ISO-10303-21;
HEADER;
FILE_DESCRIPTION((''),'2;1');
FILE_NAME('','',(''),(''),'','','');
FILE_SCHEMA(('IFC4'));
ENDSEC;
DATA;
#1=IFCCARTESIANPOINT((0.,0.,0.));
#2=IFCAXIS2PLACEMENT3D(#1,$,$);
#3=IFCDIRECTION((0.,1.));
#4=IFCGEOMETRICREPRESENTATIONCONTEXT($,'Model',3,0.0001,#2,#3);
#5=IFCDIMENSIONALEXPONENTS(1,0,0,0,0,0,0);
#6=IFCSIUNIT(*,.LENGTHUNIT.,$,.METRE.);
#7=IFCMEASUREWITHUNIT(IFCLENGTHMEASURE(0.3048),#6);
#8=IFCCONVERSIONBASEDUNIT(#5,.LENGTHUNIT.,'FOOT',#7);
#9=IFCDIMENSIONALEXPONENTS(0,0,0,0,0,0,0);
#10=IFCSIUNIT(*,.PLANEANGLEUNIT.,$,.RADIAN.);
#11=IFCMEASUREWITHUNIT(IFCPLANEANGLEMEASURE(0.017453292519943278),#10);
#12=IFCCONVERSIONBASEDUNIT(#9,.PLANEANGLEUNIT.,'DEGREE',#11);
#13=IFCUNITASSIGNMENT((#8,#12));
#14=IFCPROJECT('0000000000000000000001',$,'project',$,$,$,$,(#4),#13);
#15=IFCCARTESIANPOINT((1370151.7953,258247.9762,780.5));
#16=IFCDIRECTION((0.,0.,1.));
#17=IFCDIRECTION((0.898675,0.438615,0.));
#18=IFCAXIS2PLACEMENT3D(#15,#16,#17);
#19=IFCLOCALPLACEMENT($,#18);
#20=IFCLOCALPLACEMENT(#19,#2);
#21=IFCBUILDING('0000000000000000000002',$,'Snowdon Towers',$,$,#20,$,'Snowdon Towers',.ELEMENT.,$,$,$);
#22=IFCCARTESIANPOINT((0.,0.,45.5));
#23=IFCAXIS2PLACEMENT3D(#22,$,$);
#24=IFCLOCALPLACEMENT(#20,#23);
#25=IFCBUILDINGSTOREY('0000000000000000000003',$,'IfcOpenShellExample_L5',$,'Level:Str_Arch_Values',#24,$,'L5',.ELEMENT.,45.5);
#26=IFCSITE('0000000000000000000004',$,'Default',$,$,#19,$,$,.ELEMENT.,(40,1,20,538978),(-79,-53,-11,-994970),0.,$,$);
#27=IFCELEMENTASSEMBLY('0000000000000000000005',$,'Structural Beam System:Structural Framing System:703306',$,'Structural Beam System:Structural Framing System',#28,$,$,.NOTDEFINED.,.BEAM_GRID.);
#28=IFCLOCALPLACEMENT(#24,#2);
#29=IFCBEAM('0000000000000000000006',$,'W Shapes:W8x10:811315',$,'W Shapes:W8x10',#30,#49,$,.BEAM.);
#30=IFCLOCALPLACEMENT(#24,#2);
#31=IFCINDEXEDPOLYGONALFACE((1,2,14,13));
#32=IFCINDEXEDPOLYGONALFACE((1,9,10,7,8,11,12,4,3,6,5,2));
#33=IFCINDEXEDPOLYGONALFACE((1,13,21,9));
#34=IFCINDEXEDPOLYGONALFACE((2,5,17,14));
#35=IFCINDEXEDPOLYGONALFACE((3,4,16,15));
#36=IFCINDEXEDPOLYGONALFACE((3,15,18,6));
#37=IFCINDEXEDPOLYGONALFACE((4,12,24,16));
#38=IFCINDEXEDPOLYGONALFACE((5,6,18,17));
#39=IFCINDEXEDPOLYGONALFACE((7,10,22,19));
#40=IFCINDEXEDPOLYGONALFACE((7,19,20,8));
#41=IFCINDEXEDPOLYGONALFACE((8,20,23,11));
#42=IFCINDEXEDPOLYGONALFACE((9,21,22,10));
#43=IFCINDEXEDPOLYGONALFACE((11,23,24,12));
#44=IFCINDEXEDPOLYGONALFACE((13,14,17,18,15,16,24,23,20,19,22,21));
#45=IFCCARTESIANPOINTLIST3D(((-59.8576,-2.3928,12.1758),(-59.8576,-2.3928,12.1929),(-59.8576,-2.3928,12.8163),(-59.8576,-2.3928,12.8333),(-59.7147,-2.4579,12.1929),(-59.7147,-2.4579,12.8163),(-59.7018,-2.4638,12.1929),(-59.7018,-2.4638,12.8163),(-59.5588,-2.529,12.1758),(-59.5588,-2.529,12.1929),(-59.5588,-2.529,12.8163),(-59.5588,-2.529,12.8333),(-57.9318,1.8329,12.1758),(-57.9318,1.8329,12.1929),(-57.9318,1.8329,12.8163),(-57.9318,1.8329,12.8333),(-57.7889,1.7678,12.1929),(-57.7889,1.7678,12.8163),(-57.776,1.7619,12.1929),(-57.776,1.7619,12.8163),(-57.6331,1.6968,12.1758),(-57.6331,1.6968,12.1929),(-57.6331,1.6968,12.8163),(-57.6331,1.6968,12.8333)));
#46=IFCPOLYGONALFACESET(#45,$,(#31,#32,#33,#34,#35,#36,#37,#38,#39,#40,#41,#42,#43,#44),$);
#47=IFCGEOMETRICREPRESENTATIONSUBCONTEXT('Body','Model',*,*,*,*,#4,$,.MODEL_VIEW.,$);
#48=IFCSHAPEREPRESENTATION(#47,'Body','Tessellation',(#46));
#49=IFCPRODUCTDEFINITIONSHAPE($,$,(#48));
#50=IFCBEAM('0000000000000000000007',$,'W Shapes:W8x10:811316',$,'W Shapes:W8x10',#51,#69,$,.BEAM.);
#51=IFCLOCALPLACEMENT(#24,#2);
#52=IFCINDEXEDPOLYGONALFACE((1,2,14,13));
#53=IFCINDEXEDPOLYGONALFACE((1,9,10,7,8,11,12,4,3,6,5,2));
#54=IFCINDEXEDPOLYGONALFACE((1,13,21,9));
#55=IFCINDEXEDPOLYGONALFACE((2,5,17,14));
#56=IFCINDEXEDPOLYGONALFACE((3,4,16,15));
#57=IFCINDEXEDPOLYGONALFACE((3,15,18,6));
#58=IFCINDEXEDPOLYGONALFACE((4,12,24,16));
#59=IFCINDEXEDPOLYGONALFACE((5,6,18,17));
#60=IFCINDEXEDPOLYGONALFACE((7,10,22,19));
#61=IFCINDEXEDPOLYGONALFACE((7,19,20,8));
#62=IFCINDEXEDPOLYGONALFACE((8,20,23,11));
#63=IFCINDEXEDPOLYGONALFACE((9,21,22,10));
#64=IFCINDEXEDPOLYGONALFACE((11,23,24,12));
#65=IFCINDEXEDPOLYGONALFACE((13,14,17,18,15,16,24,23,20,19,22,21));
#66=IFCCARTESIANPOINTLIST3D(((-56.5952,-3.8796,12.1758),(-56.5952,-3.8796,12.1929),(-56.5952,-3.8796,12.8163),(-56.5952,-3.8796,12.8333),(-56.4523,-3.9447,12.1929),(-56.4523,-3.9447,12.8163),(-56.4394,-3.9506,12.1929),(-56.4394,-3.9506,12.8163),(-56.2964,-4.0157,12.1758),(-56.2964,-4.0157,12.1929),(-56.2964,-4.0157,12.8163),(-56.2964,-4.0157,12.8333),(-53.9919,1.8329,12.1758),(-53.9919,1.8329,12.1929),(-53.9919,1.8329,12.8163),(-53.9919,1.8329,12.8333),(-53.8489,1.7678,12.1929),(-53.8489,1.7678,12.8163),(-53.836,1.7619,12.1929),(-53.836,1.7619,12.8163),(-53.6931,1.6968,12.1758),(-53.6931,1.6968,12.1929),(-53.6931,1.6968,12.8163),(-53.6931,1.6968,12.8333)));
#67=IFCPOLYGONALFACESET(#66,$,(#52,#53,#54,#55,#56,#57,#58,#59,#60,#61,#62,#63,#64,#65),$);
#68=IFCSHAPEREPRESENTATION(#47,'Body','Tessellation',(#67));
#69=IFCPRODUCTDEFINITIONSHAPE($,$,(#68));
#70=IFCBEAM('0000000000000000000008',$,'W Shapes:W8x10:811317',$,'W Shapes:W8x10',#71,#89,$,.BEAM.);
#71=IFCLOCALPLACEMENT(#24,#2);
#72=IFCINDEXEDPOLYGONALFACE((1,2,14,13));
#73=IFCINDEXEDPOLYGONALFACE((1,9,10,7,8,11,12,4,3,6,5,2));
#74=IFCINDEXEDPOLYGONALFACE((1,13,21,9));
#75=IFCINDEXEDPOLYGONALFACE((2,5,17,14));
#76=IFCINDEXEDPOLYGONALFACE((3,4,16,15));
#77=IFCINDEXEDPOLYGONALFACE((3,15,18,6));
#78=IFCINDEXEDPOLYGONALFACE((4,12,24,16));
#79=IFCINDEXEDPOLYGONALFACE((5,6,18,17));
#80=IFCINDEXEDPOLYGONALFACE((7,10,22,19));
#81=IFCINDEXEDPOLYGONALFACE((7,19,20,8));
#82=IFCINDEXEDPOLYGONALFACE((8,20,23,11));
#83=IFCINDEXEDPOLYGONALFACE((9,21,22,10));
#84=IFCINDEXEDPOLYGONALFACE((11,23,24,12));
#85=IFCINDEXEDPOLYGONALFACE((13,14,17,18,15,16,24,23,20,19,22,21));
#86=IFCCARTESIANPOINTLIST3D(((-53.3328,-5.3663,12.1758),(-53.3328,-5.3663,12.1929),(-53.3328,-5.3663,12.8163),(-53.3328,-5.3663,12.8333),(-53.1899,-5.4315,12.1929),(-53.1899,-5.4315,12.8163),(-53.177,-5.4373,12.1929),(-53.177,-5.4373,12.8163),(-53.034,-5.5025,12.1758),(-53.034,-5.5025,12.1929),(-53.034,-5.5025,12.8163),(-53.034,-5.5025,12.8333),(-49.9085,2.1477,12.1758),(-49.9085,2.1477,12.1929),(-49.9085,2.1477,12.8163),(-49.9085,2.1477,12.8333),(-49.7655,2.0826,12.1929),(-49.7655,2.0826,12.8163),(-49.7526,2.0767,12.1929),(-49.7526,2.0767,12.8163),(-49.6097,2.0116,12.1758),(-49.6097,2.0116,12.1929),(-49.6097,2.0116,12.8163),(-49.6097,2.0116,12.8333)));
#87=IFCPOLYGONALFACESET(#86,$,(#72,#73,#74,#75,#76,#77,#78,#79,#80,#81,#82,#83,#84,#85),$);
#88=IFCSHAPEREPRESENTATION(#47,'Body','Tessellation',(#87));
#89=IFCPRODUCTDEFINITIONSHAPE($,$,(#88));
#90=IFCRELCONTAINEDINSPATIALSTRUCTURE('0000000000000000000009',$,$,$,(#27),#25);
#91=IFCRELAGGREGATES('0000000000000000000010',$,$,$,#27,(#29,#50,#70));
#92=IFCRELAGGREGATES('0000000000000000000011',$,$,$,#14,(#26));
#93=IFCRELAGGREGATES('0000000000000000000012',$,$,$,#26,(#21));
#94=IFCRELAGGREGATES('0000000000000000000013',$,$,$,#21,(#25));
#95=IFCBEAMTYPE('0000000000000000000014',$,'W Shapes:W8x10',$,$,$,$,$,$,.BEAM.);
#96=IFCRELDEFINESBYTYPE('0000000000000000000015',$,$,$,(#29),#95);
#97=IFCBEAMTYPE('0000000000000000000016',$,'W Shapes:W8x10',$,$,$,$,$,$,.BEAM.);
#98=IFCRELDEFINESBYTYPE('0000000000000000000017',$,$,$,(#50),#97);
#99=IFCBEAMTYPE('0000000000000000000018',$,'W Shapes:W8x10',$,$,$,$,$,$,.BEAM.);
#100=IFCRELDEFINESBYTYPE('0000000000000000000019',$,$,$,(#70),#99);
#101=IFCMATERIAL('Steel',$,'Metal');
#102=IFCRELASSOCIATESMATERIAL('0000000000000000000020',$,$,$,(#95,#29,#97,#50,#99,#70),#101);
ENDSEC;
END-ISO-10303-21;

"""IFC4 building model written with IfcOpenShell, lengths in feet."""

from ifc_helpers import new_model, entity, si_unit, converted_unit, direction, frame, origin, place, context, subcontext, project, spatial, indexed_curve, outline, extrude, source, transform, mapped, material, type_object, type_shapes, element, aggregate, save


model = new_model("IFC4")

# Units and contexts
model_context = context("Model", 3, precision=0.0001, world=origin(), true_north=direction((0.0, 1.0)))
body_context = subcontext(model_context, "Body", "Model", "MODEL_VIEW")
ifc_project = project(units=[converted_unit("LENGTHUNIT", "FOOT", entity("IfcLengthMeasure", 0.3048), si_unit("LENGTHUNIT", "METRE"), dimensions=[1, 0, 0, 0, 0, 0, 0]), converted_unit("PLANEANGLEUNIT", "DEGREE", entity("IfcPlaneAngleMeasure", 0.017453292519943278), si_unit("PLANEANGLEUNIT", "RADIAN"), dimensions=[0, 0, 0, 0, 0, 0, 0])], contexts=[model_context])

# Site, building, storey
site_placement = place(None, frame((1370151.7953, 258247.9762, 780.5), z_axis=(0.0, 0.0, 1.0), x_axis=(0.898675, 0.438615, 0.0)))
site = spatial("IfcSite", under=ifc_project, at=site_placement, Name="Default", CompositionType="ELEMENT", RefLatitude=(40, 1, 20, 538978), RefLongitude=(-79, -53, -11, -994970), RefElevation=0.0)
building_placement = place(site_placement, origin())
building = spatial("IfcBuilding", under=site, at=building_placement, Name="Snowdon Towers", LongName="Snowdon Towers", CompositionType="ELEMENT")
storey_placement = place(building_placement, frame((0.0, 0.0, 45.5)))
storey = spatial("IfcBuildingStorey", under=building, at=storey_placement, Name="IfcOpenShellExample_L5", ObjectType="Level:Str_Arch_Values", LongName="L5", CompositionType="ELEMENT", Elevation=45.5)

# Shared definitions
ifc_material = material(Name="Steel", Category="Metal")

# Element assembly, beams
assembly_1_placement = place(storey_placement, origin())
assembly_1 = element("IfcElementAssembly", 1, at=assembly_1_placement, inside=storey, Name="Structural Beam System:Structural Framing System:703306", ObjectType="Structural Beam System:Structural Framing System", AssemblyPlace="NOTDEFINED", PredefinedType="BEAM_GRID")
beam_type_1 = type_object("IfcBeamType", Name="W Shapes:W8x10", PredefinedType="BEAM", material=ifc_material)
shared_shape_1 = source(origin(), body_context, "Body", "SweptSolid", [
    extrude(outline(indexed_curve([(-0.1642, -0.3117), (-0.1642, -0.3288), (0.1642, -0.3288), (0.1642, -0.3117), (0.0071, -0.3117), (0.0071, 0.3117), (0.1642, 0.3117), (0.1642, 0.3287), (-0.1642, 0.3287), (-0.1642, 0.3117), (-0.0071, 0.3117), (-0.0071, -0.3117), (-0.1642, -0.3117)], self_intersect=False)), frame((-2.5698, 0.0, 0.0), z_axis=(-1.0, 0.0, 0.0), x_axis=(0.0, -1.0, 0.0)), (0.0, 0.0, -1.0), 4.6438),
])
type_shapes(beam_type_1, [shared_shape_1])
beam_1_placement = place(assembly_1_placement, frame((-58.6425, -0.1224, 12.5046), z_axis=(0.0, 0.0, 1.0), x_axis=(0.414693, 0.909961, 0.0)))
beam_1 = element("IfcBeam", 2, at=beam_1_placement, type_object=beam_type_1, material=ifc_material, Name="W Shapes:W8x10:811315", ObjectType="W Shapes:W8x10", PredefinedType="BEAM", context=body_context, shape_type="MappedRepresentation", body=[
    mapped(shared_shape_1, transform((0.0, 0.0, 0.0), scale=1.0)),
])
beam_type_2 = type_object("IfcBeamType", Name="W Shapes:W8x10", PredefinedType="BEAM", material=ifc_material)
shared_shape_2 = source(origin(), body_context, "Body", "SweptSolid", [
    extrude(outline(indexed_curve([(-0.1642, -0.3117), (-0.1642, -0.3288), (0.1642, -0.3288), (0.1642, -0.3117), (0.0071, -0.3117), (0.0071, 0.3117), (0.1642, 0.3117), (0.1642, 0.3287), (-0.1642, 0.3287), (-0.1642, 0.3117), (-0.0071, 0.3117), (-0.0071, -0.3117), (-0.1642, -0.3117)], self_intersect=False)), frame((-3.3868, 0.0, 0.0), z_axis=(-1.0, 0.0, 0.0), x_axis=(0.0, -1.0, 0.0)), (0.0, 0.0, -1.0), 6.2777),
])
type_shapes(beam_type_2, [shared_shape_2])
beam_2_placement = place(assembly_1_placement, frame((-55.0413, -0.8658, 12.5046), z_axis=(0.0, 0.0, 1.0), x_axis=(0.414693, 0.909961, 0.0)))
beam_2 = element("IfcBeam", 3, at=beam_2_placement, type_object=beam_type_2, material=ifc_material, Name="W Shapes:W8x10:811316", ObjectType="W Shapes:W8x10", PredefinedType="BEAM", context=body_context, shape_type="MappedRepresentation", body=[
    mapped(shared_shape_2, transform((0.0, 0.0, 0.0), scale=1.0)),
])
beam_type_3 = type_object("IfcBeamType", Name="W Shapes:W8x10", PredefinedType="BEAM", material=ifc_material)
shared_shape_3 = source(origin(), body_context, "Body", "SweptSolid", [
    extrude(outline(indexed_curve([(-0.1642, -0.3117), (-0.1642, -0.3288), (0.1642, -0.3288), (0.1642, -0.3117), (0.0071, -0.3117), (0.0071, 0.3117), (0.1642, 0.3117), (0.1642, 0.3287), (-0.1642, 0.3287), (-0.1642, 0.3117), (-0.0071, 0.3117), (-0.0071, -0.3117), (-0.1642, -0.3117)], self_intersect=False)), frame((-4.2037, 0.0, 0.0), z_axis=(-1.0, 0.0, 0.0), x_axis=(0.0, -1.0, 0.0)), (0.0, 0.0, -1.0), 8.2576),
])
type_shapes(beam_type_3, [shared_shape_3])
beam_3_placement = place(assembly_1_placement, frame((-51.4402, -1.6092, 12.5046), z_axis=(0.0, 0.0, 1.0), x_axis=(0.414693, 0.909961, 0.0)))
beam_3 = element("IfcBeam", 4, at=beam_3_placement, type_object=beam_type_3, material=ifc_material, Name="W Shapes:W8x10:811317", ObjectType="W Shapes:W8x10", PredefinedType="BEAM", context=body_context, shape_type="MappedRepresentation", body=[
    mapped(shared_shape_3, transform((0.0, 0.0, 0.0), scale=1.0)),
])
aggregate(assembly_1, [beam_1, beam_2, beam_3])

save(model, "model.ifc")
